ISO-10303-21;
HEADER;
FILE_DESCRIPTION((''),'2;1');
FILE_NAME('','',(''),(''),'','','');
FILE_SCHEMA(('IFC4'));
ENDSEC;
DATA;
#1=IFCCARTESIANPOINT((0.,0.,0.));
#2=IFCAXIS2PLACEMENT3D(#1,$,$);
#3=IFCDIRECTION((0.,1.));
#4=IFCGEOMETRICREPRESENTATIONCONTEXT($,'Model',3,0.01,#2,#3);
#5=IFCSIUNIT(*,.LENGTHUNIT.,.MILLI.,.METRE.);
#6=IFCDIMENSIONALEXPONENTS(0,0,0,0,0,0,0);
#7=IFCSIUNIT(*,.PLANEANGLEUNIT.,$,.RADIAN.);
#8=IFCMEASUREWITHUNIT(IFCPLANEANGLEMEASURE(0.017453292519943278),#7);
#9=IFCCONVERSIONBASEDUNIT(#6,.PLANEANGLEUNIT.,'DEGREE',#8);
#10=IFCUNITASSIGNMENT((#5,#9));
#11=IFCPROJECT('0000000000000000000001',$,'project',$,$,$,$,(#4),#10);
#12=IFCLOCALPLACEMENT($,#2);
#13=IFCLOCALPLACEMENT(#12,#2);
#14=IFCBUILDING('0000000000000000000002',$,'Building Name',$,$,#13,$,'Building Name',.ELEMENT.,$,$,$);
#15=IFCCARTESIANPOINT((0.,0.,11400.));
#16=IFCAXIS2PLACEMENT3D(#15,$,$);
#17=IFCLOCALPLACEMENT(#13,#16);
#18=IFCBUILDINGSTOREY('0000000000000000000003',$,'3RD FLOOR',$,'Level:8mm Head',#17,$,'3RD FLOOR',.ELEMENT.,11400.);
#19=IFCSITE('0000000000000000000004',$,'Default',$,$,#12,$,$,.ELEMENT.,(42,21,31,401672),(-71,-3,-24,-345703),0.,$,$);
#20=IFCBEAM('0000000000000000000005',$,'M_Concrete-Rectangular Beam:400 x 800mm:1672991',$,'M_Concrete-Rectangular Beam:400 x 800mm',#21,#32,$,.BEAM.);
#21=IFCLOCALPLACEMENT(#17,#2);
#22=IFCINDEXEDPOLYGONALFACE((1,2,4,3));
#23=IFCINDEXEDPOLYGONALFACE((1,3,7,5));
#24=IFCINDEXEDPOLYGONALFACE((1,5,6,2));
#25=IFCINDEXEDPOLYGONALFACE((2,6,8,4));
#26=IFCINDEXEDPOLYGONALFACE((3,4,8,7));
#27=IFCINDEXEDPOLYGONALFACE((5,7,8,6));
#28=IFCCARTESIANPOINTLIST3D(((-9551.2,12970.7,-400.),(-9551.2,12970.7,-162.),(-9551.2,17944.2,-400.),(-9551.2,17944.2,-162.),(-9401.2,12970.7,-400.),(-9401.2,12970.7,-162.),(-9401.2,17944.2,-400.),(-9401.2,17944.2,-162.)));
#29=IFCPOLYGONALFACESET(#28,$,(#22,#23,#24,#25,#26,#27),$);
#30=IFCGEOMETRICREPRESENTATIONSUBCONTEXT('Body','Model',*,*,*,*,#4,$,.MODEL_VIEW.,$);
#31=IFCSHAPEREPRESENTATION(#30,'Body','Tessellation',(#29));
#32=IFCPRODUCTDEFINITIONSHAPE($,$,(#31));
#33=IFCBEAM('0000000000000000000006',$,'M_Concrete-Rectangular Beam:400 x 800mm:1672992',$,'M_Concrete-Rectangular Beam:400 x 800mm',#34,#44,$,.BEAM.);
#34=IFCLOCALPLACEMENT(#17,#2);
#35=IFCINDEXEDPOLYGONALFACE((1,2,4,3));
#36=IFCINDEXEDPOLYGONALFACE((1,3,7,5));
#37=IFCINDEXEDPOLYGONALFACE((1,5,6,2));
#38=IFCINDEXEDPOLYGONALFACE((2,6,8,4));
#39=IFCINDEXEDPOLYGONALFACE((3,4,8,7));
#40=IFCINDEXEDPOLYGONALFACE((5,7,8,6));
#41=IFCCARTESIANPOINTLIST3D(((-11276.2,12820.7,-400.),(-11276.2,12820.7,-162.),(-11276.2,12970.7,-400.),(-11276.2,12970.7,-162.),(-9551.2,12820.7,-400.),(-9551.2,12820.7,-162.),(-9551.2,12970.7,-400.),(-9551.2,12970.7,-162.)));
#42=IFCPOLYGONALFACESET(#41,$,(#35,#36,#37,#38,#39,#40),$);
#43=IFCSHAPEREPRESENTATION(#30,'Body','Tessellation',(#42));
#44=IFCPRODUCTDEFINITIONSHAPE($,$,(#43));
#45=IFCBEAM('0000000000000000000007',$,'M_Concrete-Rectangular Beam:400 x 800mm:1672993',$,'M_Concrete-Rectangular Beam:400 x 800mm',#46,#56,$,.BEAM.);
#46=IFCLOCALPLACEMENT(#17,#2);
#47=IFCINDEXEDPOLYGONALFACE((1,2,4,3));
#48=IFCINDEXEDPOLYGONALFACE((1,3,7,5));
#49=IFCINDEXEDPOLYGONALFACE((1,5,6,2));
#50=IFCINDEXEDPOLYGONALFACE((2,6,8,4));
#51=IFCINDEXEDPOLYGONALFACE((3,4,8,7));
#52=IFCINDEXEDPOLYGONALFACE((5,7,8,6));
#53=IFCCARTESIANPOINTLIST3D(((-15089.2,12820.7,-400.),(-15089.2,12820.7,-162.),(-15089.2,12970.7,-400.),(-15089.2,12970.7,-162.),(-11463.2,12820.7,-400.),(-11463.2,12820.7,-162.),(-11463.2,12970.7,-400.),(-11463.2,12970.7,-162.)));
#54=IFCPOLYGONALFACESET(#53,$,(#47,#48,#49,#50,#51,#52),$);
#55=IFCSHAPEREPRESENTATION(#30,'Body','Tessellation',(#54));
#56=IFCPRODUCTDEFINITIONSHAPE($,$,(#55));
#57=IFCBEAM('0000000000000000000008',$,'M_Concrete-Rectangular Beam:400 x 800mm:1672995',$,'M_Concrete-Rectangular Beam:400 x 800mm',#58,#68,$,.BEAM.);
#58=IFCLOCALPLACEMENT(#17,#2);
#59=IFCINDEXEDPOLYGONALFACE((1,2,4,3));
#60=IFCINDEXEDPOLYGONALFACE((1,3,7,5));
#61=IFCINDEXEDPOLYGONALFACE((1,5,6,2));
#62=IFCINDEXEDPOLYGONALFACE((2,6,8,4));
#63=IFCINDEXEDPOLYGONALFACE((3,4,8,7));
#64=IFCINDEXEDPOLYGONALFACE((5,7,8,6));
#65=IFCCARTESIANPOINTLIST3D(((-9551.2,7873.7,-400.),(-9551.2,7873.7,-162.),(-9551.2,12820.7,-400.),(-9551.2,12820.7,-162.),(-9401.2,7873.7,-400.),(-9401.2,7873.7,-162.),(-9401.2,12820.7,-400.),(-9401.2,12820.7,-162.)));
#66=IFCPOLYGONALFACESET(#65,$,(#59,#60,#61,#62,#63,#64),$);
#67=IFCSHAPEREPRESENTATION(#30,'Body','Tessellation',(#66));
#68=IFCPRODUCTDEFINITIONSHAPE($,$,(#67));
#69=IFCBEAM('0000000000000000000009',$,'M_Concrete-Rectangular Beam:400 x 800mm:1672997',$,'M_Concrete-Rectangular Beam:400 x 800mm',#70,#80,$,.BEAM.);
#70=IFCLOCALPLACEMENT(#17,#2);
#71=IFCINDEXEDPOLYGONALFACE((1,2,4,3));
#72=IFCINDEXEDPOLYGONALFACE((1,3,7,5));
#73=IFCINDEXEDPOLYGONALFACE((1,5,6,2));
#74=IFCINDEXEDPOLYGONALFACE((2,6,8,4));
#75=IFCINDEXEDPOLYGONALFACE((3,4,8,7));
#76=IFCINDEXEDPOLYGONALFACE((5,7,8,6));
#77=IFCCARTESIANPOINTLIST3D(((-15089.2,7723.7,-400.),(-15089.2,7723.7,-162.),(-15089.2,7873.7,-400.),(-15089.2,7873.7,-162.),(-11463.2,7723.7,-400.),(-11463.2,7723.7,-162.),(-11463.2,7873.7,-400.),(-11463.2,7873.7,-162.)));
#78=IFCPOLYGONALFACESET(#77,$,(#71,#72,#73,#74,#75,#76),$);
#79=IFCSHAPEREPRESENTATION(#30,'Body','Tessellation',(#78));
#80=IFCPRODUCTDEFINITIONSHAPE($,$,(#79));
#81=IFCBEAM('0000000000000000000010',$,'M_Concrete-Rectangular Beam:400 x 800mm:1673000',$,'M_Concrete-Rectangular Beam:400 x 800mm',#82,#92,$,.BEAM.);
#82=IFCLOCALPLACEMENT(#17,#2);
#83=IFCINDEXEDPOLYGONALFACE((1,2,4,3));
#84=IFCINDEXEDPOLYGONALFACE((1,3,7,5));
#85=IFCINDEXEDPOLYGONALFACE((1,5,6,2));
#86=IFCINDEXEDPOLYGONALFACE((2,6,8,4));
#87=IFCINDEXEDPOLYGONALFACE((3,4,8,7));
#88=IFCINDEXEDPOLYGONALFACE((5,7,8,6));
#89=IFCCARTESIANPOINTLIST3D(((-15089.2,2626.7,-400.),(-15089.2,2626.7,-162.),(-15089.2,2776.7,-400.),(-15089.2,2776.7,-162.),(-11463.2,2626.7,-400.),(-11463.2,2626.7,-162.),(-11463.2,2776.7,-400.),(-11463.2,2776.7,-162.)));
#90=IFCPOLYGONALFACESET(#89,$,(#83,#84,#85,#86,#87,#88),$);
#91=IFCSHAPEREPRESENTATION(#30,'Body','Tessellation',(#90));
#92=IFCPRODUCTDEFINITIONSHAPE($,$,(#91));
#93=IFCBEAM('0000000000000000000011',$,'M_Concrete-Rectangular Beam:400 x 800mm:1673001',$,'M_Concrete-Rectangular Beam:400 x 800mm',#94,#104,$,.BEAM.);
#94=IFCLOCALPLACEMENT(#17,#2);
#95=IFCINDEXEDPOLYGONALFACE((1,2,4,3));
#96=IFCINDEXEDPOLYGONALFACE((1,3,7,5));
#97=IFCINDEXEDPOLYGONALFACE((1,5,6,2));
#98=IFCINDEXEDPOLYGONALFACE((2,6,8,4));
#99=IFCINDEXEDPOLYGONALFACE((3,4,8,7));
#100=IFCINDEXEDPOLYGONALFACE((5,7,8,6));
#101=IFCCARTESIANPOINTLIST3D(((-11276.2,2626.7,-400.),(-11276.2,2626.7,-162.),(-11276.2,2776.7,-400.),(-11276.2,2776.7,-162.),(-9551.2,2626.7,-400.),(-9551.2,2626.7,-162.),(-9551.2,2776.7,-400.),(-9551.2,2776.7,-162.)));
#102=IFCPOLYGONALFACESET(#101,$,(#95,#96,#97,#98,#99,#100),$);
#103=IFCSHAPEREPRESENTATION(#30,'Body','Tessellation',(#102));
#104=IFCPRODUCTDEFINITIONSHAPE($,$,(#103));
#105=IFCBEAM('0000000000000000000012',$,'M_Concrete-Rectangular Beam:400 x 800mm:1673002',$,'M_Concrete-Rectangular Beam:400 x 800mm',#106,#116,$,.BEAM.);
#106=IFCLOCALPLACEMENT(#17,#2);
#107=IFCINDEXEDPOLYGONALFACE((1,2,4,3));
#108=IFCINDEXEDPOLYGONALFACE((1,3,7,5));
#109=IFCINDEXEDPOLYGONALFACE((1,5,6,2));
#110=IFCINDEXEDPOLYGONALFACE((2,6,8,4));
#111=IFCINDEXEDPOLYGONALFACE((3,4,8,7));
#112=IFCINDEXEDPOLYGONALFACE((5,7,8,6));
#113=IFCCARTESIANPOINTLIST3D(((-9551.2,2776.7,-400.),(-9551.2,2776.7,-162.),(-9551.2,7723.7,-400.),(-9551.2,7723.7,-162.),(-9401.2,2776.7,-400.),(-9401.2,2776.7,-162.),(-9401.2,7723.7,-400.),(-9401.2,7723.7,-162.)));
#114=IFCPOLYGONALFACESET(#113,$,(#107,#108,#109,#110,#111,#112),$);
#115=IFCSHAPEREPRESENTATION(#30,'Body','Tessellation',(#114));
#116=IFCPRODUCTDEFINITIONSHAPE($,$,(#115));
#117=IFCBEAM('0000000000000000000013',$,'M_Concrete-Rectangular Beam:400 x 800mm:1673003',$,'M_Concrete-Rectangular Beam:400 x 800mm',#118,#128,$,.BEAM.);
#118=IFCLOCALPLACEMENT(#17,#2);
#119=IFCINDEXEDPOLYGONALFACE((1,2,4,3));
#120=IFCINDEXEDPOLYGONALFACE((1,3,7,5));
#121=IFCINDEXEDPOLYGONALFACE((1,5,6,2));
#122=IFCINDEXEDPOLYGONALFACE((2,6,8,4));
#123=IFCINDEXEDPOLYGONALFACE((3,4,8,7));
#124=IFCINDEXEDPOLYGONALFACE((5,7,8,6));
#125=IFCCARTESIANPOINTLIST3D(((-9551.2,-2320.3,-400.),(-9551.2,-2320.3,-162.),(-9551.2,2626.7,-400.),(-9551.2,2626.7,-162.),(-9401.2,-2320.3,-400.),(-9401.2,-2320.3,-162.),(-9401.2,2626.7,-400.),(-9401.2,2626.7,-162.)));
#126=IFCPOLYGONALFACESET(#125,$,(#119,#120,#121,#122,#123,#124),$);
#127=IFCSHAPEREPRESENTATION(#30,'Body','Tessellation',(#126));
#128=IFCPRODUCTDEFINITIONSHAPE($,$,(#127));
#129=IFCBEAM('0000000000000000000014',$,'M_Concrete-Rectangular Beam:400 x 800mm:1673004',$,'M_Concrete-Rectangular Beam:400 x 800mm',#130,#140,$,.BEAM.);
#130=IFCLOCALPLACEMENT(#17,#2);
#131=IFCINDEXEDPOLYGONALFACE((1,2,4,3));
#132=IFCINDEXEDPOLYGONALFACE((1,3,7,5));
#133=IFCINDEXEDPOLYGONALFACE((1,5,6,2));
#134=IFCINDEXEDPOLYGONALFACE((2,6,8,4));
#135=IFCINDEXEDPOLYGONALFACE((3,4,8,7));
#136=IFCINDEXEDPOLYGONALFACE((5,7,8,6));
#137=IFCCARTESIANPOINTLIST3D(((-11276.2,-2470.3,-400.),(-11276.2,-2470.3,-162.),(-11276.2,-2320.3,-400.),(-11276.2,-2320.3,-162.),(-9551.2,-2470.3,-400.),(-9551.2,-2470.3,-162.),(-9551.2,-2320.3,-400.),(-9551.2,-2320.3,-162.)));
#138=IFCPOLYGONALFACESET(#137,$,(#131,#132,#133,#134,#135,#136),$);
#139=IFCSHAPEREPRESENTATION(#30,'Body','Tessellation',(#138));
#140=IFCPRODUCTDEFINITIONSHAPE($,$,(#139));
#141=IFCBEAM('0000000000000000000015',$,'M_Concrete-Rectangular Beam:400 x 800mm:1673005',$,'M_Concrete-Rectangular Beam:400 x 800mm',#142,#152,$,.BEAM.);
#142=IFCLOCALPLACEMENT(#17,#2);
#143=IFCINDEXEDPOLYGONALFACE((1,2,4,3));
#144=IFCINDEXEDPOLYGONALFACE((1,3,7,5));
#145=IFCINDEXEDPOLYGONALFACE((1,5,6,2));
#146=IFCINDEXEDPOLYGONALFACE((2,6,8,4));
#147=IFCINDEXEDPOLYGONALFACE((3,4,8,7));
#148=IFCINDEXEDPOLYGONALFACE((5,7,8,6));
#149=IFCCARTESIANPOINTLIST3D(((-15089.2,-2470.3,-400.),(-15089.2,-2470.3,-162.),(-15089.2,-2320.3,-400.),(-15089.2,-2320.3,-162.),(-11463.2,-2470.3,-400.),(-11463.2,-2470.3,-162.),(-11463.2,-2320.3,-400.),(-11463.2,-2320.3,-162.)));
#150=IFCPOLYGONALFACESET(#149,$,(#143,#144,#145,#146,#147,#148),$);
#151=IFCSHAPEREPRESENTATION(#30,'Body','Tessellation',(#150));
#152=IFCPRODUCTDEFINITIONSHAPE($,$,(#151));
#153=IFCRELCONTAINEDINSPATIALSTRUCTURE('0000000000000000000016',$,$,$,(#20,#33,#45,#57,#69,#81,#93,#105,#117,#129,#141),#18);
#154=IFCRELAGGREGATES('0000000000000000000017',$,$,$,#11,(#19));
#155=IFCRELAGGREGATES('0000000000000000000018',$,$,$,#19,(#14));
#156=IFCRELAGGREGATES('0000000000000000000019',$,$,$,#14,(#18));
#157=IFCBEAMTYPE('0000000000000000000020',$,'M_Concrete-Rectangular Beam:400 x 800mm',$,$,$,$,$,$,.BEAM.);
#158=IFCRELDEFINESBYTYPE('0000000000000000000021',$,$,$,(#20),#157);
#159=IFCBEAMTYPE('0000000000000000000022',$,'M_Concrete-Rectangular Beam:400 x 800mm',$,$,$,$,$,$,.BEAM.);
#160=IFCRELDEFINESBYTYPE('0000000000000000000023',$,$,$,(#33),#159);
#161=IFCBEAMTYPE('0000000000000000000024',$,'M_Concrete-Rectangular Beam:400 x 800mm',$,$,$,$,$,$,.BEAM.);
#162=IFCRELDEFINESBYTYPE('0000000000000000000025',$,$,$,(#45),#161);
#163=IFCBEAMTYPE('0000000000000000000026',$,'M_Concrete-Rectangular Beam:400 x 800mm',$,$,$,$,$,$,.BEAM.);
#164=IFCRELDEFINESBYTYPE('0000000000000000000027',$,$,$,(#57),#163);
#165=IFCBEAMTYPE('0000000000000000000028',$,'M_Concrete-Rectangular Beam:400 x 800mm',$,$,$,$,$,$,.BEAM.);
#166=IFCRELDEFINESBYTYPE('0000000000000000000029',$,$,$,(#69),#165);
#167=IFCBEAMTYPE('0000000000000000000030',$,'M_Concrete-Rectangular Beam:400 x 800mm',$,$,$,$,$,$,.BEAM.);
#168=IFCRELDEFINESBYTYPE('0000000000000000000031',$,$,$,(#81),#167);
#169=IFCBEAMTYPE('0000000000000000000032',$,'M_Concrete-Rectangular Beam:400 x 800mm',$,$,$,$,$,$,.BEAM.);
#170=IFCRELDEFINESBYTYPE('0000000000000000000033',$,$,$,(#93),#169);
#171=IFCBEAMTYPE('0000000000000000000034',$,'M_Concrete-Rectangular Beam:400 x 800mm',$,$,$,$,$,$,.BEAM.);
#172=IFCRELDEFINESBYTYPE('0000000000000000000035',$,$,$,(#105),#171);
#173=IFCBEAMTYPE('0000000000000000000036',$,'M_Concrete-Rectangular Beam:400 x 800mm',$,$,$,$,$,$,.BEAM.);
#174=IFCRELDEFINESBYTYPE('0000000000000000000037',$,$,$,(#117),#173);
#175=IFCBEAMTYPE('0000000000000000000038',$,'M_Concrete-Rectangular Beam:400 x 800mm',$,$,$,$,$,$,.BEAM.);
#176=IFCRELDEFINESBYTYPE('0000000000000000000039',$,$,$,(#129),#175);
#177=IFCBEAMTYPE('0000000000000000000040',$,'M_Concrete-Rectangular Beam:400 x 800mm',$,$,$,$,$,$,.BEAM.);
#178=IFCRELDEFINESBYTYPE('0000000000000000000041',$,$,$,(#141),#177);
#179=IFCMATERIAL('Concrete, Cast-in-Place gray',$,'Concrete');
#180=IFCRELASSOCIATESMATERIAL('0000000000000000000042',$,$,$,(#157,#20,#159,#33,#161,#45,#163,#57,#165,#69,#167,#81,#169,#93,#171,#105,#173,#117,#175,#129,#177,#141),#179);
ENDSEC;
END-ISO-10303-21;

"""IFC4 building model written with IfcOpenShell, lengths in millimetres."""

from ifc_helpers import new_model, entity, si_unit, converted_unit, direction, frame, origin, place, context, subcontext, project, spatial, indexed_curve, outline, extrude, source, transform, mapped, material, type_object, type_shapes, element, save


model = new_model("IFC4")

# Units and contexts
model_context = context("Model", 3, precision=0.01, world=origin(), true_north=direction((0.0, 1.0)))
body_context = subcontext(model_context, "Body", "Model", "MODEL_VIEW")
ifc_project = project(units=[si_unit("LENGTHUNIT", "METRE", prefix="MILLI"), converted_unit("PLANEANGLEUNIT", "DEGREE", entity("IfcPlaneAngleMeasure", 0.017453292519943278), si_unit("PLANEANGLEUNIT", "RADIAN"), dimensions=[0, 0, 0, 0, 0, 0, 0])], contexts=[model_context])

# Site, building, storey
site_placement = place(None, origin())
site = spatial("IfcSite", under=ifc_project, at=site_placement, Name="Default", CompositionType="ELEMENT", RefLatitude=(42, 21, 31, 401672), RefLongitude=(-71, -3, -24, -345703), RefElevation=0.0)
building_placement = place(site_placement, origin())
building = spatial("IfcBuilding", under=site, at=building_placement, Name="Building Name", LongName="Building Name", CompositionType="ELEMENT")
storey_placement = place(building_placement, frame((0.0, 0.0, 11400.0)))
storey = spatial("IfcBuildingStorey", under=building, at=storey_placement, Name="3RD FLOOR", ObjectType="Level:8mm Head", LongName="3RD FLOOR", CompositionType="ELEMENT", Elevation=11400.0)

# Beams
ifc_material = material(Name="Concrete, Cast-in-Place gray", Category="Concrete")
beam_type_1 = type_object("IfcBeamType", Name="M_Concrete-Rectangular Beam:400 x 800mm", PredefinedType="BEAM", material=ifc_material)
shared_shape_1 = source(origin(), body_context, "Body", "SweptSolid", [
    extrude(outline(indexed_curve([(-75.0, -119.0), (75.0, -119.0), (75.0, 119.0), (-75.0, 119.0), (-75.0, -119.0)], self_intersect=False)), frame((-9476.2, 17944.2, 11119.0), z_axis=(0.0, -1.0, 0.0), x_axis=(-1.0, 0.0, 0.0)), (0.0, 0.0, 1.0), 4973.5),
])
type_shapes(beam_type_1, [shared_shape_1])
beam_1_placement = place(storey_placement, frame((0.0, 0.0, -11400.0)))
element("IfcBeam", 1, at=beam_1_placement, inside=storey, type_object=beam_type_1, material=ifc_material, Name="M_Concrete-Rectangular Beam:400 x 800mm:1672991", ObjectType="M_Concrete-Rectangular Beam:400 x 800mm", PredefinedType="BEAM", context=body_context, shape_type="MappedRepresentation", body=[
    mapped(shared_shape_1, transform((0.0, 0.0, 0.0), scale=1.0)),
])
beam_type_2 = type_object("IfcBeamType", Name="M_Concrete-Rectangular Beam:400 x 800mm", PredefinedType="BEAM", material=ifc_material)
shared_shape_2 = source(origin(), body_context, "Body", "SweptSolid", [
    extrude(outline(indexed_curve([(-119.0, -75.0), (119.0, -75.0), (119.0, 75.0), (-119.0, 75.0), (-119.0, -75.0)], self_intersect=False)), frame((-9551.2, 12895.7, 11119.0), z_axis=(-1.0, 0.0, 0.0), x_axis=(0.0, 0.0, -1.0)), (0.0, 0.0, 1.0), 1725.0),
])
type_shapes(beam_type_2, [shared_shape_2])
beam_2_placement = place(storey_placement, frame((0.0, 0.0, -11400.0)))
element("IfcBeam", 2, at=beam_2_placement, inside=storey, type_object=beam_type_2, material=ifc_material, Name="M_Concrete-Rectangular Beam:400 x 800mm:1672992", ObjectType="M_Concrete-Rectangular Beam:400 x 800mm", PredefinedType="BEAM", context=body_context, shape_type="MappedRepresentation", body=[
    mapped(shared_shape_2, transform((0.0, 0.0, 0.0), scale=1.0)),
])
beam_type_3 = type_object("IfcBeamType", Name="M_Concrete-Rectangular Beam:400 x 800mm", PredefinedType="BEAM", material=ifc_material)
shared_shape_3 = source(origin(), body_context, "Body", "SweptSolid", [
    extrude(outline(indexed_curve([(-119.0, -75.0), (119.0, -75.0), (119.0, 75.0), (-119.0, 75.0), (-119.0, -75.0)], self_intersect=False)), frame((-11463.2, 12895.7, 11119.0), z_axis=(-1.0, 0.0, 0.0), x_axis=(0.0, 0.0, -1.0)), (0.0, 0.0, 1.0), 3626.0),
])
type_shapes(beam_type_3, [shared_shape_3])
beam_3_placement = place(storey_placement, frame((0.0, 0.0, -11400.0)))
element("IfcBeam", 3, at=beam_3_placement, inside=storey, type_object=beam_type_3, material=ifc_material, Name="M_Concrete-Rectangular Beam:400 x 800mm:1672993", ObjectType="M_Concrete-Rectangular Beam:400 x 800mm", PredefinedType="BEAM", context=body_context, shape_type="MappedRepresentation", body=[
    mapped(shared_shape_3, transform((0.0, 0.0, 0.0), scale=1.0)),
])
beam_type_4 = type_object("IfcBeamType", Name="M_Concrete-Rectangular Beam:400 x 800mm", PredefinedType="BEAM", material=ifc_material)
shared_shape_4 = source(origin(), body_context, "Body", "SweptSolid", [
    extrude(outline(indexed_curve([(-75.0, -119.0), (75.0, -119.0), (75.0, 119.0), (-75.0, 119.0), (-75.0, -119.0)], self_intersect=False)), frame((-9476.2, 12820.7, 11119.0), z_axis=(0.0, -1.0, 0.0), x_axis=(-1.0, 0.0, 0.0)), (0.0, 0.0, 1.0), 4947.0),
])
type_shapes(beam_type_4, [shared_shape_4])
beam_4_placement = place(storey_placement, frame((0.0, 0.0, -11400.0)))
element("IfcBeam", 4, at=beam_4_placement, inside=storey, type_object=beam_type_4, material=ifc_material, Name="M_Concrete-Rectangular Beam:400 x 800mm:1672995", ObjectType="M_Concrete-Rectangular Beam:400 x 800mm", PredefinedType="BEAM", context=body_context, shape_type="MappedRepresentation", body=[
    mapped(shared_shape_4, transform((0.0, 0.0, 0.0), scale=1.0)),
])
beam_type_5 = type_object("IfcBeamType", Name="M_Concrete-Rectangular Beam:400 x 800mm", PredefinedType="BEAM", material=ifc_material)
shared_shape_5 = source(origin(), body_context, "Body", "SweptSolid", [
    extrude(outline(indexed_curve([(-119.0, -75.0), (119.0, -75.0), (119.0, 75.0), (-119.0, 75.0), (-119.0, -75.0)], self_intersect=False)), frame((-11463.2, 7798.7, 11119.0), z_axis=(-1.0, 0.0, 0.0), x_axis=(0.0, 0.0, -1.0)), (0.0, 0.0, 1.0), 3626.0),
])
type_shapes(beam_type_5, [shared_shape_5])
beam_5_placement = place(storey_placement, frame((0.0, 0.0, -11400.0)))
element("IfcBeam", 5, at=beam_5_placement, inside=storey, type_object=beam_type_5, material=ifc_material, Name="M_Concrete-Rectangular Beam:400 x 800mm:1672997", ObjectType="M_Concrete-Rectangular Beam:400 x 800mm", PredefinedType="BEAM", context=body_context, shape_type="MappedRepresentation", body=[
    mapped(shared_shape_5, transform((0.0, 0.0, 0.0), scale=1.0)),
])
beam_type_6 = type_object("IfcBeamType", Name="M_Concrete-Rectangular Beam:400 x 800mm", PredefinedType="BEAM", material=ifc_material)
shared_shape_6 = source(origin(), body_context, "Body", "SweptSolid", [
    extrude(outline(indexed_curve([(-119.0, -75.0), (119.0, -75.0), (119.0, 75.0), (-119.0, 75.0), (-119.0, -75.0)], self_intersect=False)), frame((-15089.2, 2701.7, 11119.0), z_axis=(1.0, 0.0, 0.0), x_axis=(0.0, 0.0, -1.0)), (0.0, 0.0, 1.0), 3626.0),
])
type_shapes(beam_type_6, [shared_shape_6])
beam_6_placement = place(storey_placement, frame((0.0, 0.0, -11400.0)))
element("IfcBeam", 6, at=beam_6_placement, inside=storey, type_object=beam_type_6, material=ifc_material, Name="M_Concrete-Rectangular Beam:400 x 800mm:1673000", ObjectType="M_Concrete-Rectangular Beam:400 x 800mm", PredefinedType="BEAM", context=body_context, shape_type="MappedRepresentation", body=[
    mapped(shared_shape_6, transform((0.0, 0.0, 0.0), scale=1.0)),
])
beam_type_7 = type_object("IfcBeamType", Name="M_Concrete-Rectangular Beam:400 x 800mm", PredefinedType="BEAM", material=ifc_material)
shared_shape_7 = source(origin(), body_context, "Body", "SweptSolid", [
    extrude(outline(indexed_curve([(-119.0, -75.0), (119.0, -75.0), (119.0, 75.0), (-119.0, 75.0), (-119.0, -75.0)], self_intersect=False)), frame((-11276.2, 2701.7, 11119.0), z_axis=(1.0, 0.0, 0.0), x_axis=(0.0, 0.0, -1.0)), (0.0, 0.0, 1.0), 1725.0),
])
type_shapes(beam_type_7, [shared_shape_7])
beam_7_placement = place(storey_placement, frame((0.0, 0.0, -11400.0)))
element("IfcBeam", 7, at=beam_7_placement, inside=storey, type_object=beam_type_7, material=ifc_material, Name="M_Concrete-Rectangular Beam:400 x 800mm:1673001", ObjectType="M_Concrete-Rectangular Beam:400 x 800mm", PredefinedType="BEAM", context=body_context, shape_type="MappedRepresentation", body=[
    mapped(shared_shape_7, transform((0.0, 0.0, 0.0), scale=1.0)),
])
beam_type_8 = type_object("IfcBeamType", Name="M_Concrete-Rectangular Beam:400 x 800mm", PredefinedType="BEAM", material=ifc_material)
shared_shape_8 = source(origin(), body_context, "Body", "SweptSolid", [
    extrude(outline(indexed_curve([(-75.0, -119.0), (75.0, -119.0), (75.0, 119.0), (-75.0, 119.0), (-75.0, -119.0)], self_intersect=False)), frame((-9476.2, 2776.7, 11119.0), z_axis=(0.0, 1.0, 0.0), x_axis=(-1.0, 0.0, 0.0)), (0.0, 0.0, 1.0), 4947.0),
])
type_shapes(beam_type_8, [shared_shape_8])
beam_8_placement = place(storey_placement, frame((0.0, 0.0, -11400.0)))
element("IfcBeam", 8, at=beam_8_placement, inside=storey, type_object=beam_type_8, material=ifc_material, Name="M_Concrete-Rectangular Beam:400 x 800mm:1673002", ObjectType="M_Concrete-Rectangular Beam:400 x 800mm", PredefinedType="BEAM", context=body_context, shape_type="MappedRepresentation", body=[
    mapped(shared_shape_8, transform((0.0, 0.0, 0.0), scale=1.0)),
])
beam_type_9 = type_object("IfcBeamType", Name="M_Concrete-Rectangular Beam:400 x 800mm", PredefinedType="BEAM", material=ifc_material)
shared_shape_9 = source(origin(), body_context, "Body", "SweptSolid", [
    extrude(outline(indexed_curve([(-75.0, -119.0), (75.0, -119.0), (75.0, 119.0), (-75.0, 119.0), (-75.0, -119.0)], self_intersect=False)), frame((-9476.2, 2626.7, 11119.0), z_axis=(0.0, -1.0, 0.0), x_axis=(-1.0, 0.0, 0.0)), (0.0, 0.0, 1.0), 4947.0),
])
type_shapes(beam_type_9, [shared_shape_9])
beam_9_placement = place(storey_placement, frame((0.0, 0.0, -11400.0)))
element("IfcBeam", 9, at=beam_9_placement, inside=storey, type_object=beam_type_9, material=ifc_material, Name="M_Concrete-Rectangular Beam:400 x 800mm:1673003", ObjectType="M_Concrete-Rectangular Beam:400 x 800mm", PredefinedType="BEAM", context=body_context, shape_type="MappedRepresentation", body=[
    mapped(shared_shape_9, transform((0.0, 0.0, 0.0), scale=1.0)),
])
beam_type_10 = type_object("IfcBeamType", Name="M_Concrete-Rectangular Beam:400 x 800mm", PredefinedType="BEAM", material=ifc_material)
shared_shape_10 = source(origin(), body_context, "Body", "SweptSolid", [
    extrude(outline(indexed_curve([(-119.0, -75.0), (119.0, -75.0), (119.0, 75.0), (-119.0, 75.0), (-119.0, -75.0)], self_intersect=False)), frame((-9551.2, -2395.3, 11119.0), z_axis=(-1.0, 0.0, 0.0), x_axis=(0.0, 0.0, -1.0)), (0.0, 0.0, 1.0), 1725.0),
])
type_shapes(beam_type_10, [shared_shape_10])
beam_10_placement = place(storey_placement, frame((0.0, 0.0, -11400.0)))
element("IfcBeam", 10, at=beam_10_placement, inside=storey, type_object=beam_type_10, material=ifc_material, Name="M_Concrete-Rectangular Beam:400 x 800mm:1673004", ObjectType="M_Concrete-Rectangular Beam:400 x 800mm", PredefinedType="BEAM", context=body_context, shape_type="MappedRepresentation", body=[
    mapped(shared_shape_10, transform((0.0, 0.0, 0.0), scale=1.0)),
])
beam_type_11 = type_object("IfcBeamType", Name="M_Concrete-Rectangular Beam:400 x 800mm", PredefinedType="BEAM", material=ifc_material)
shared_shape_11 = source(origin(), body_context, "Body", "SweptSolid", [
    extrude(outline(indexed_curve([(-119.0, -75.0), (119.0, -75.0), (119.0, 75.0), (-119.0, 75.0), (-119.0, -75.0)], self_intersect=False)), frame((-11463.2, -2395.3, 11119.0), z_axis=(-1.0, 0.0, 0.0), x_axis=(0.0, 0.0, -1.0)), (0.0, 0.0, 1.0), 3626.0),
])
type_shapes(beam_type_11, [shared_shape_11])
beam_11_placement = place(storey_placement, frame((0.0, 0.0, -11400.0)))
element("IfcBeam", 11, at=beam_11_placement, inside=storey, type_object=beam_type_11, material=ifc_material, Name="M_Concrete-Rectangular Beam:400 x 800mm:1673005", ObjectType="M_Concrete-Rectangular Beam:400 x 800mm", PredefinedType="BEAM", context=body_context, shape_type="MappedRepresentation", body=[
    mapped(shared_shape_11, transform((0.0, 0.0, 0.0), scale=1.0)),
])

save(model, "model.ifc")
